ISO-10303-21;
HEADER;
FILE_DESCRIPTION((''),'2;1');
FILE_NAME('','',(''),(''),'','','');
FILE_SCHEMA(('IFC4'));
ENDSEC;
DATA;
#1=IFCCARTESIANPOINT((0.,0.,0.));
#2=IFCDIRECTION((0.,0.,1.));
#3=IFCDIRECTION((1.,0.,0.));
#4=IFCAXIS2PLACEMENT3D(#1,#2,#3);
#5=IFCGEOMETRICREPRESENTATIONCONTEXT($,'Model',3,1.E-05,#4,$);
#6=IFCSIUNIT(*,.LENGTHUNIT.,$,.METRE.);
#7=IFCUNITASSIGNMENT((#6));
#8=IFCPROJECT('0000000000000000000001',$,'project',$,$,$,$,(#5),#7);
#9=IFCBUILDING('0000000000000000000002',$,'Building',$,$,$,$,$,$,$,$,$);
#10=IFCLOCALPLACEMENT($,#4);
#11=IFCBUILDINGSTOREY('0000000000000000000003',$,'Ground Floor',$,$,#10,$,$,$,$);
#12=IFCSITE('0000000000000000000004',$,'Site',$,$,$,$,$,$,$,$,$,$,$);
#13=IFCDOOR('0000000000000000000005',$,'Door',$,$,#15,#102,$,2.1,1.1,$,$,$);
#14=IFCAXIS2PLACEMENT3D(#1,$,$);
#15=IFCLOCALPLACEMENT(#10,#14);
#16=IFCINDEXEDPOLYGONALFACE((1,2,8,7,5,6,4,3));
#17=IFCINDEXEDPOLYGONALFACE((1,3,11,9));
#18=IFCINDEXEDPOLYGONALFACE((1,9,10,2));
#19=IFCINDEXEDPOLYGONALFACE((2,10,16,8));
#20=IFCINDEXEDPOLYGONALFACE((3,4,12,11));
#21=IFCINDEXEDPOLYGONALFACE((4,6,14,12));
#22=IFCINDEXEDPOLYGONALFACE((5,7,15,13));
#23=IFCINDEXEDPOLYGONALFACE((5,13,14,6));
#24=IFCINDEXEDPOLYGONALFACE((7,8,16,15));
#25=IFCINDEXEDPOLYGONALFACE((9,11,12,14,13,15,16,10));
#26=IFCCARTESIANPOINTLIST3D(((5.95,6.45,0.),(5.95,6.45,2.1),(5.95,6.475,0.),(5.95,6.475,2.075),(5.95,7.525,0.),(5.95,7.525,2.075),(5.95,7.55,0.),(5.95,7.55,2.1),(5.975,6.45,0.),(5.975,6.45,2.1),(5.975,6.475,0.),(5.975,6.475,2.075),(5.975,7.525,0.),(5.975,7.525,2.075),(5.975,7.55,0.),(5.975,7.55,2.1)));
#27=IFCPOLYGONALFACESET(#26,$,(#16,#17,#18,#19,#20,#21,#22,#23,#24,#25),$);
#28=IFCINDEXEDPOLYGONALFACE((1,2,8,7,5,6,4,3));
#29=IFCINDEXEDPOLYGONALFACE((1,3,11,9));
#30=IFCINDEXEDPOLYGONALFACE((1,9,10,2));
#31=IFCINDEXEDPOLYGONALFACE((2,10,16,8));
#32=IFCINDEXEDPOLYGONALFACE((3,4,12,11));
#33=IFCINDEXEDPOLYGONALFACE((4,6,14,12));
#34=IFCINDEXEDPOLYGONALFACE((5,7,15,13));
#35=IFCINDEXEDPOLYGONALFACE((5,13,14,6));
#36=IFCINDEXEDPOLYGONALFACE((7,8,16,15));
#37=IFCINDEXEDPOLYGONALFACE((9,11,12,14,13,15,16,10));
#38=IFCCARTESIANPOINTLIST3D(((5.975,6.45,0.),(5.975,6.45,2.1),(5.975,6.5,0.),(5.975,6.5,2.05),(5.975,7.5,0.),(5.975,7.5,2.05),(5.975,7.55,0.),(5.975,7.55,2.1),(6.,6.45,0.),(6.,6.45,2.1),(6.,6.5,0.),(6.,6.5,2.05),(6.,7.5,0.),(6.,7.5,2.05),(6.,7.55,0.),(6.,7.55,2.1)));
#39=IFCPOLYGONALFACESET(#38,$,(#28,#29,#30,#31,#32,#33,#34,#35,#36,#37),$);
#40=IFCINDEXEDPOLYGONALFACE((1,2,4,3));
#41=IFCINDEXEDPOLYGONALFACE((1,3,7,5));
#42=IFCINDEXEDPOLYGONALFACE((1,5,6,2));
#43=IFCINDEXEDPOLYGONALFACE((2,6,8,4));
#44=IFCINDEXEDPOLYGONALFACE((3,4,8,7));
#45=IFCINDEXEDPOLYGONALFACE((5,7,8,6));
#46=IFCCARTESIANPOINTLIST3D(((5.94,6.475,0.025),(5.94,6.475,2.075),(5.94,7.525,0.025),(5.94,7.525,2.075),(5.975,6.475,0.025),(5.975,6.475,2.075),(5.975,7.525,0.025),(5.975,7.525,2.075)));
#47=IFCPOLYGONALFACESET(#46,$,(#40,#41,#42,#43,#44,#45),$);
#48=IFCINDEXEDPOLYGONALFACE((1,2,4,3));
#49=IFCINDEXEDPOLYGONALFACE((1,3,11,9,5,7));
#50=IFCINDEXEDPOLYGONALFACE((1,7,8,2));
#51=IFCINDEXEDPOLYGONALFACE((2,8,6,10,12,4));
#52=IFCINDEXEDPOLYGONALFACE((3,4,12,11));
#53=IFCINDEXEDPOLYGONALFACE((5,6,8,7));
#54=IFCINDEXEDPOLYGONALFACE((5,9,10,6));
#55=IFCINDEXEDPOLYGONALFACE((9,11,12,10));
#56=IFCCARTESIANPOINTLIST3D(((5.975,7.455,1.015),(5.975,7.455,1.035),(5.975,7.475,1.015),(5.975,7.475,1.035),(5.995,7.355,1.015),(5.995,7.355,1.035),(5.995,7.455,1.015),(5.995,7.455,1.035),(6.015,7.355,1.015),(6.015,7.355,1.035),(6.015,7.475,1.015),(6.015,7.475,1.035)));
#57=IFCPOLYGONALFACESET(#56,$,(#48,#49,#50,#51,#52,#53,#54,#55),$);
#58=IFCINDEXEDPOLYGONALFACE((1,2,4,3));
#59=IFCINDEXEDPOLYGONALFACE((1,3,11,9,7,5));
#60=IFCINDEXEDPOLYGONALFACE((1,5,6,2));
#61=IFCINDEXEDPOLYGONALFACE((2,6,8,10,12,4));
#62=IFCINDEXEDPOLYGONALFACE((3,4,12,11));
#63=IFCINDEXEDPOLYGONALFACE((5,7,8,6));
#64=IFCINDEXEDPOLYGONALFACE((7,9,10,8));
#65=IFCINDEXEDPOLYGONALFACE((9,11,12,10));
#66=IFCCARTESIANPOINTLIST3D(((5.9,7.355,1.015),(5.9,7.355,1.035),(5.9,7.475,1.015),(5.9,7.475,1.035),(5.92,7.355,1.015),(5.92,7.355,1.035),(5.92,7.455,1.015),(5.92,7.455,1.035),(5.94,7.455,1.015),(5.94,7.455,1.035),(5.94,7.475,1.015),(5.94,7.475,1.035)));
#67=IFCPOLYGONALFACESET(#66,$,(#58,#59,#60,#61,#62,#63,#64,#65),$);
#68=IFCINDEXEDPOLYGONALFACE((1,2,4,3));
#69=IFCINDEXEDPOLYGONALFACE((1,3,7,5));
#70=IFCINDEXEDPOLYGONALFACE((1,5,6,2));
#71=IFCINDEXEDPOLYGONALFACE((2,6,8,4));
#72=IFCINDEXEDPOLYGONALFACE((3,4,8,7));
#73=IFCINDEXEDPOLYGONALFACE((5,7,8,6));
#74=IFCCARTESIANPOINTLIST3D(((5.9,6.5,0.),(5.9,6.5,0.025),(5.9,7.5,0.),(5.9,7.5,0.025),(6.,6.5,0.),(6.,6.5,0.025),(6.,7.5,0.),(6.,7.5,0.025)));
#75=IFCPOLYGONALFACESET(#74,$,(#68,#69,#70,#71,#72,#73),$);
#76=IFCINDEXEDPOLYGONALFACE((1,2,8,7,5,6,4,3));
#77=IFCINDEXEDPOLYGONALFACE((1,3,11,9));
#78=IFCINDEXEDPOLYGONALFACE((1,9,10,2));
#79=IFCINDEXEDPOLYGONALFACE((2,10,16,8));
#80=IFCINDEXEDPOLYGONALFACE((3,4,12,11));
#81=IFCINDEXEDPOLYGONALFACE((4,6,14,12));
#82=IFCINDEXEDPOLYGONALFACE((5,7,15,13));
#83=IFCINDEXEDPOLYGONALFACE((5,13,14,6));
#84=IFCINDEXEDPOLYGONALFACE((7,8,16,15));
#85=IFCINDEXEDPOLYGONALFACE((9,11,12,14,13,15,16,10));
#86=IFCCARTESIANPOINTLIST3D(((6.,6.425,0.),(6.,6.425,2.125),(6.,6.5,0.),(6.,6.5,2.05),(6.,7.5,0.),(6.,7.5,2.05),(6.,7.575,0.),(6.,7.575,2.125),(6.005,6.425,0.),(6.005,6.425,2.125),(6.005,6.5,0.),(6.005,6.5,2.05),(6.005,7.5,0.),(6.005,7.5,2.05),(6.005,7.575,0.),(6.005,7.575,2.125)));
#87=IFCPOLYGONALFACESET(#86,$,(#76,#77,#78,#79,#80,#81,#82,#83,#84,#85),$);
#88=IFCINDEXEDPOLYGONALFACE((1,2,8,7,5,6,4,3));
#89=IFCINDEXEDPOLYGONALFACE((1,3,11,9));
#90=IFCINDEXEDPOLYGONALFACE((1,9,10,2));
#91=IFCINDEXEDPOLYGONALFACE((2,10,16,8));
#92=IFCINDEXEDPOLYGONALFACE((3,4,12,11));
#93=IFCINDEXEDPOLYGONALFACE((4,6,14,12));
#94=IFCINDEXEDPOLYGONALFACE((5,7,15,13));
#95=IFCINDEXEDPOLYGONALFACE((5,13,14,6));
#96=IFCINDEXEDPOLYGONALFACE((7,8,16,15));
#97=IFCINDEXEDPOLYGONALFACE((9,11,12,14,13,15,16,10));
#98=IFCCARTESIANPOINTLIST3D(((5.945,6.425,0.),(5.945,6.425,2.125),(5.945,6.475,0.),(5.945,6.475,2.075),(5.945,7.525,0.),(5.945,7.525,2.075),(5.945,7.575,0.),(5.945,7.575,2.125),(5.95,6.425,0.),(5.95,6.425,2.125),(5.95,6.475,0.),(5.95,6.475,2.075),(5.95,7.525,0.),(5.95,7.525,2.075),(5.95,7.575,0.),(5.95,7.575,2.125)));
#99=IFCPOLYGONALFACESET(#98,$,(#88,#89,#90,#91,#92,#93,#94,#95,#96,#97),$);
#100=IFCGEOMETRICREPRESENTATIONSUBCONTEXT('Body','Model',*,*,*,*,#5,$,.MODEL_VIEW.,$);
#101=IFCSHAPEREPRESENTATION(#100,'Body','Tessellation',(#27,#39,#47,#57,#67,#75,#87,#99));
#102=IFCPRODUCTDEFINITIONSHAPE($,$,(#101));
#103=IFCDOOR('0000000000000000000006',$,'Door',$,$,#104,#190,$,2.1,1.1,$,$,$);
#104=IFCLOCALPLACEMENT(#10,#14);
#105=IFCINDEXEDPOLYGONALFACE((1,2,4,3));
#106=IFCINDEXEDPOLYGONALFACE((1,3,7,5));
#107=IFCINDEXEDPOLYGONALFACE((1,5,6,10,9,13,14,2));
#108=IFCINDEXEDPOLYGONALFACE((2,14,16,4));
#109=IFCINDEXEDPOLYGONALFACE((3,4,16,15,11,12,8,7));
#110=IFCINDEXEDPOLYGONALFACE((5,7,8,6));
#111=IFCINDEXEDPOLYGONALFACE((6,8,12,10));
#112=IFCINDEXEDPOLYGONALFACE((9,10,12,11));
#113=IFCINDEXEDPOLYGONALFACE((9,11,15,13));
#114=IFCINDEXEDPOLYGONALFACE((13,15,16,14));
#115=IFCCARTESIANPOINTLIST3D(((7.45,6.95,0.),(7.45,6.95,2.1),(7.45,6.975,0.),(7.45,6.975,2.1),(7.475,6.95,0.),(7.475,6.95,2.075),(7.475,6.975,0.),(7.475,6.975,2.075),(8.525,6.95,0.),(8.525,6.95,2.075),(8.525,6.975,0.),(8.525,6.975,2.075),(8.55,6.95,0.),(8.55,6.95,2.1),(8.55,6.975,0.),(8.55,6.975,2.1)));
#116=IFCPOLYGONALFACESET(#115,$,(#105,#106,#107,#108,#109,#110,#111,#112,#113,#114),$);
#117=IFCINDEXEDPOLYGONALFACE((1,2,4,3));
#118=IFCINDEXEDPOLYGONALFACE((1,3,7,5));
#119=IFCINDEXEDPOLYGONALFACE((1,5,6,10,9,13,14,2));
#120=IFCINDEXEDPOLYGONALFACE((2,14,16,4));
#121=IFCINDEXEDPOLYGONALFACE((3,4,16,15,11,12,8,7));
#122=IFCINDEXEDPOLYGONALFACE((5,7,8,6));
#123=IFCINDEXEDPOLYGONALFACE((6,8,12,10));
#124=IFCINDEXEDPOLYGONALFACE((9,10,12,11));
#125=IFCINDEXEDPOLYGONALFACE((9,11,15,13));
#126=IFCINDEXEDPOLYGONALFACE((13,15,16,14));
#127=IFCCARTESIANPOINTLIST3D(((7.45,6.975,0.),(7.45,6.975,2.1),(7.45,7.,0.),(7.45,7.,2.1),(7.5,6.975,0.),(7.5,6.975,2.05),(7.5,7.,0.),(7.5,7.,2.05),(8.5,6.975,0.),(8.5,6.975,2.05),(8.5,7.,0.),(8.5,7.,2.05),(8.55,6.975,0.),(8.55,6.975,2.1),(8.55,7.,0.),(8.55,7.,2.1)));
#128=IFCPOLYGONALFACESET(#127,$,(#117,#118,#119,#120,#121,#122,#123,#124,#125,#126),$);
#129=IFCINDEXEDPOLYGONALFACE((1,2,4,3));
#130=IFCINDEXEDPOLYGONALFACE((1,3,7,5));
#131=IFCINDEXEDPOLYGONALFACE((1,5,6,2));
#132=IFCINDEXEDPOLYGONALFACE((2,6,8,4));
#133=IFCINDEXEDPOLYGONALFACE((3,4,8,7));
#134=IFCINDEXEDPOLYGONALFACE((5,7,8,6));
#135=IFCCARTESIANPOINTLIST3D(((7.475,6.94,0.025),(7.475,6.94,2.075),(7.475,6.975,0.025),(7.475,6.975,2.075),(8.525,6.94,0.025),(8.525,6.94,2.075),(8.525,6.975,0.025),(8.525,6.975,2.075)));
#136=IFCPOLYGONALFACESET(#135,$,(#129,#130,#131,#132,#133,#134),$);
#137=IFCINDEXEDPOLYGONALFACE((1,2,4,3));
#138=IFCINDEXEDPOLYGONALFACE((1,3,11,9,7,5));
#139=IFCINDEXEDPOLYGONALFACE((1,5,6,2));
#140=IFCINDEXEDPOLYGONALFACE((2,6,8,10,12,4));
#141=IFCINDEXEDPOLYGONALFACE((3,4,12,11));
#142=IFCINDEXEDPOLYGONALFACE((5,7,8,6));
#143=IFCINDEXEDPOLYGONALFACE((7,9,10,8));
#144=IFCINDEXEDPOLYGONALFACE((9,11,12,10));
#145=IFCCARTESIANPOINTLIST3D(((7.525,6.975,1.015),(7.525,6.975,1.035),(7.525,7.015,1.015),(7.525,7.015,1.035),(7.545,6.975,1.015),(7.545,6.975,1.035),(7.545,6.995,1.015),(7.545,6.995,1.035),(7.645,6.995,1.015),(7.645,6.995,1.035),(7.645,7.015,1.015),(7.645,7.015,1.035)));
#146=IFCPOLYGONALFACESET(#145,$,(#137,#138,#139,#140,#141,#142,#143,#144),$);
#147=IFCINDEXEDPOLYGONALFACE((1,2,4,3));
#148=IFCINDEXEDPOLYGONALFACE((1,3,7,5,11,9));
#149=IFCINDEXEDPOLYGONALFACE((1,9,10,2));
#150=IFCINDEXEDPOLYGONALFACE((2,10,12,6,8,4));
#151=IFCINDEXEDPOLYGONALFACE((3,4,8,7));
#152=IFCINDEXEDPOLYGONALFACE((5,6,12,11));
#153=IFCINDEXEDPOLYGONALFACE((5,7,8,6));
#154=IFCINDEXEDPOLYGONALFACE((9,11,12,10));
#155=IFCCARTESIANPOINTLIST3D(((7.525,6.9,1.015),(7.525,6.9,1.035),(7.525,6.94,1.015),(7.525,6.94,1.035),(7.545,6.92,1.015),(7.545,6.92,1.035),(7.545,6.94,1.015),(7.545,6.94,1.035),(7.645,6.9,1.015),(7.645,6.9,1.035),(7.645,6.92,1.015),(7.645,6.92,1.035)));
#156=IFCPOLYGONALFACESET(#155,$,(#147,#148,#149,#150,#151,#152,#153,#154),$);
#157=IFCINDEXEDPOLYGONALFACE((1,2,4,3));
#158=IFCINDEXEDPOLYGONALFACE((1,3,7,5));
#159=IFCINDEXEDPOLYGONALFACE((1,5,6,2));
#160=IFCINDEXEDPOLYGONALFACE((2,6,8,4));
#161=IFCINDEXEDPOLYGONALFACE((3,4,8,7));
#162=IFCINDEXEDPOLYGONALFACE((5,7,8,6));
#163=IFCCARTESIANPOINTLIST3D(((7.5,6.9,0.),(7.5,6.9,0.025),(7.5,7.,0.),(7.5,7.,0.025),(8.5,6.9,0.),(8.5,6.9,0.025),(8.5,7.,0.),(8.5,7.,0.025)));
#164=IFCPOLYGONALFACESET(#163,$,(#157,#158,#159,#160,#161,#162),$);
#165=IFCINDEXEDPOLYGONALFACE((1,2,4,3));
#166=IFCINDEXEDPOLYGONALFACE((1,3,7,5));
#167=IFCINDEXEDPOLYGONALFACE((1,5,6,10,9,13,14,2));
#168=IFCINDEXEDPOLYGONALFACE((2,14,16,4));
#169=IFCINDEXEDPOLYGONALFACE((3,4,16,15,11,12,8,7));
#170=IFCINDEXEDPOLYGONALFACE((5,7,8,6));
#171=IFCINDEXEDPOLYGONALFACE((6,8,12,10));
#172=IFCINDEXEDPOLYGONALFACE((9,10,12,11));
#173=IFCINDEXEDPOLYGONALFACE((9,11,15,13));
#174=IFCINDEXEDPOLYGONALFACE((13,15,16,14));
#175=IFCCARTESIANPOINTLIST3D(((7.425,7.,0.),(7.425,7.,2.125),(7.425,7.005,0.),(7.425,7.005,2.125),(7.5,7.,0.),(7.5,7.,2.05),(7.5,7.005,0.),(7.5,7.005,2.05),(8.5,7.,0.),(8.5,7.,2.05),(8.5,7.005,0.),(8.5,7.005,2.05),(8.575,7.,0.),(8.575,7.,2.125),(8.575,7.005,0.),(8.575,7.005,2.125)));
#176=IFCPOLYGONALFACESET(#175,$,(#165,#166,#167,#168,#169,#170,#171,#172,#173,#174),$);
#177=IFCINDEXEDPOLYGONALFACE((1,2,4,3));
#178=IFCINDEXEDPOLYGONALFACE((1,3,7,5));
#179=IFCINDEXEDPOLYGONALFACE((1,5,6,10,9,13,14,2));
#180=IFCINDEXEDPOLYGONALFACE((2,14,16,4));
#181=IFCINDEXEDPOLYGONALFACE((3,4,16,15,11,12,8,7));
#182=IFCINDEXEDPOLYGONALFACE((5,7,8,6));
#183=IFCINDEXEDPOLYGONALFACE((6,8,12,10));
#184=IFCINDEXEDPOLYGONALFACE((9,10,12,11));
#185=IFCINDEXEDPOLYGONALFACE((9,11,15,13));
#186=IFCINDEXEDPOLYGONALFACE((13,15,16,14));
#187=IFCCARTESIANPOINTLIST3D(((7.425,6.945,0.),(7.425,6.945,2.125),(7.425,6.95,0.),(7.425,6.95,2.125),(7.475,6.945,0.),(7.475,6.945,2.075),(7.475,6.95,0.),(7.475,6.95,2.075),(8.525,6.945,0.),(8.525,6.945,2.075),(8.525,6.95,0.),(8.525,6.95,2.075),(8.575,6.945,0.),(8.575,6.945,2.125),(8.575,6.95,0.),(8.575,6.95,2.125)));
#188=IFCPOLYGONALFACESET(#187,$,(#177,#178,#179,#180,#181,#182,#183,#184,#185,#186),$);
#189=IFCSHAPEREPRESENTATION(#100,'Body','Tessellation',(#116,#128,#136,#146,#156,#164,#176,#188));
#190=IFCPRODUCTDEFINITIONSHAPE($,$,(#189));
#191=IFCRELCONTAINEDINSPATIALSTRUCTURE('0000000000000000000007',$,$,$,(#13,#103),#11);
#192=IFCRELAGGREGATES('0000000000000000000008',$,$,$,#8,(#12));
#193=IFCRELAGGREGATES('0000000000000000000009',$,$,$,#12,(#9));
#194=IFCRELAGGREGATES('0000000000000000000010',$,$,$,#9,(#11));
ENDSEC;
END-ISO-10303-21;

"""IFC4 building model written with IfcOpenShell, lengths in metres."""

from ifc_helpers import new_model, si_unit, frame, origin_with_axes, place, context, subcontext, project, spatial, line, indexed_curve, outline, extrude, element, save


model = new_model("IFC4")

# Units and contexts
model_context = context("Model", 3, precision=1e-05, world=origin_with_axes())
body_context = subcontext(model_context, "Body", "Model", "MODEL_VIEW")
ifc_project = project(units=[si_unit("LENGTHUNIT", "METRE")], contexts=[model_context])

# Site, building, storey
site = spatial("IfcSite", under=ifc_project, Name="Site")
building = spatial("IfcBuilding", under=site, Name="Building")
storey_placement = place(None, origin_with_axes())
storey = spatial("IfcBuildingStorey", under=building, at=storey_placement, Name="Ground Floor")

# Doors
door_1_placement = place(storey_placement, frame((6.0, 6.45, 0.0), z_axis=(0.0, 0.0, 1.0), x_axis=(0.0, 1.0, 0.0)))
element("IfcDoor", 1, at=door_1_placement, inside=storey, Name="Door", OverallHeight=2.1, OverallWidth=1.1, context=body_context, shape_type="SweptSolid", body=[
    extrude(outline(indexed_curve([(0.0, 0.0), (0.0, 2.1), (1.1, 2.1), (1.1, 0.0), (1.075, 0.0), (1.075, 2.075), (0.025, 2.075), (0.025, 0.0)], segments=[line(1, 2, 3, 4, 5, 6, 7, 8, 1)])), frame((0.0, 0.025, 0.0), z_axis=(0.0, -1.0, 0.0), x_axis=(1.0, 0.0, 0.0)), (0.0, 0.0, -1.0), 0.025),
    extrude(outline(indexed_curve([(0.0, 0.0), (0.0, 2.1), (1.1, 2.1), (1.1, 0.0), (1.05, 0.0), (1.05, 2.05), (0.05, 2.05), (0.05, 0.0)], segments=[line(1, 2, 3, 4, 5, 6, 7, 8, 1)])), frame((0.0, 0.0, 0.0), z_axis=(0.0, -1.0, 0.0), x_axis=(1.0, 0.0, 0.0)), (0.0, 0.0, -1.0), 0.025),
    extrude(outline(indexed_curve([(0.0, 0.0), (1.05, 0.0), (1.05, 0.035), (0.0, 0.035)], segments=[line(1, 2, 3, 4, 1)])), frame((0.025, 0.025, 0.025), z_axis=(0.0, 0.0, 1.0), x_axis=(1.0, 0.0, 0.0)), (0.0, 0.0, 1.0), 2.05),
    extrude(outline(indexed_curve([(0.0, 0.0), (0.0, -0.04), (-0.12, -0.04), (-0.12, -0.02), (-0.02, -0.02), (-0.02, 0.0)], segments=[line(1, 2, 3, 4, 5, 6, 1)])), frame((1.025, 0.025, 1.015), z_axis=(0.0, 0.0, 1.0), x_axis=(1.0, 0.0, 0.0)), (0.0, 0.0, 1.0), 0.02),
    extrude(outline(indexed_curve([(0.0, 0.0), (0.0, 0.04), (-0.12, 0.04), (-0.12, 0.02), (-0.02, 0.02), (-0.02, 0.0)], segments=[line(1, 2, 3, 4, 5, 6, 1)])), frame((1.025, 0.06, 1.015), z_axis=(0.0, 0.0, 1.0), x_axis=(1.0, 0.0, 0.0)), (0.0, 0.0, 1.0), 0.02),
    extrude(outline(indexed_curve([(0.0, 0.0), (1.0, 0.0), (1.0, 0.1), (0.0, 0.1)], segments=[line(1, 2, 3, 4, 1)])), frame((0.05, 0.0, 0.0), z_axis=(0.0, 0.0, 1.0), x_axis=(1.0, 0.0, 0.0)), (0.0, 0.0, 1.0), 0.025),
    extrude(outline(indexed_curve([(0.0, 0.0), (0.0, 2.125), (1.15, 2.125), (1.15, 0.0), (1.075, 0.0), (1.075, 2.05), (0.075, 2.05), (0.075, 0.0)], segments=[line(1, 2, 3, 4, 5, 6, 7, 8, 1)])), frame((-0.025, -0.005, 0.0), z_axis=(0.0, -1.0, 0.0), x_axis=(1.0, 0.0, 0.0)), (0.0, 0.0, -1.0), 0.005),
    extrude(outline(indexed_curve([(0.0, 0.0), (0.0, 2.125), (1.15, 2.125), (1.15, 0.0), (1.1, 0.0), (1.1, 2.075), (0.05, 2.075), (0.05, 0.0)], segments=[line(1, 2, 3, 4, 5, 6, 7, 8, 1)])), frame((-0.025, 0.05, 0.0), z_axis=(0.0, -1.0, 0.0), x_axis=(1.0, 0.0, 0.0)), (0.0, 0.0, -1.0), 0.005),
])
door_2_placement = place(storey_placement, frame((8.55, 7.0, 0.0), z_axis=(0.0, 0.0, 1.0), x_axis=(-1.0, 0.0, 0.0)))
element("IfcDoor", 2, at=door_2_placement, inside=storey, Name="Door", OverallHeight=2.1, OverallWidth=1.1, context=body_context, shape_type="SweptSolid", body=[
    extrude(outline(indexed_curve([(0.0, 0.0), (0.0, 2.1), (1.1, 2.1), (1.1, 0.0), (1.075, 0.0), (1.075, 2.075), (0.025, 2.075), (0.025, 0.0)], segments=[line(1, 2, 3, 4, 5, 6, 7, 8, 1)])), frame((0.0, 0.025, 0.0), z_axis=(0.0, -1.0, 0.0), x_axis=(1.0, 0.0, 0.0)), (0.0, 0.0, -1.0), 0.025),
    extrude(outline(indexed_curve([(0.0, 0.0), (0.0, 2.1), (1.1, 2.1), (1.1, 0.0), (1.05, 0.0), (1.05, 2.05), (0.05, 2.05), (0.05, 0.0)], segments=[line(1, 2, 3, 4, 5, 6, 7, 8, 1)])), frame((0.0, 0.0, 0.0), z_axis=(0.0, -1.0, 0.0), x_axis=(1.0, 0.0, 0.0)), (0.0, 0.0, -1.0), 0.025),
    extrude(outline(indexed_curve([(0.0, 0.0), (1.05, 0.0), (1.05, 0.035), (0.0, 0.035)], segments=[line(1, 2, 3, 4, 1)])), frame((0.025, 0.025, 0.025), z_axis=(0.0, 0.0, 1.0), x_axis=(1.0, 0.0, 0.0)), (0.0, 0.0, 1.0), 2.05),
    extrude(outline(indexed_curve([(0.0, 0.0), (0.0, -0.04), (-0.12, -0.04), (-0.12, -0.02), (-0.02, -0.02), (-0.02, 0.0)], segments=[line(1, 2, 3, 4, 5, 6, 1)])), frame((1.025, 0.025, 1.015), z_axis=(0.0, 0.0, 1.0), x_axis=(1.0, 0.0, 0.0)), (0.0, 0.0, 1.0), 0.02),
    extrude(outline(indexed_curve([(0.0, 0.0), (0.0, 0.04), (-0.12, 0.04), (-0.12, 0.02), (-0.02, 0.02), (-0.02, 0.0)], segments=[line(1, 2, 3, 4, 5, 6, 1)])), frame((1.025, 0.06, 1.015), z_axis=(0.0, 0.0, 1.0), x_axis=(1.0, 0.0, 0.0)), (0.0, 0.0, 1.0), 0.02),
    extrude(outline(indexed_curve([(0.0, 0.0), (1.0, 0.0), (1.0, 0.1), (0.0, 0.1)], segments=[line(1, 2, 3, 4, 1)])), frame((0.05, 0.0, 0.0), z_axis=(0.0, 0.0, 1.0), x_axis=(1.0, 0.0, 0.0)), (0.0, 0.0, 1.0), 0.025),
    extrude(outline(indexed_curve([(0.0, 0.0), (0.0, 2.125), (1.15, 2.125), (1.15, 0.0), (1.075, 0.0), (1.075, 2.05), (0.075, 2.05), (0.075, 0.0)], segments=[line(1, 2, 3, 4, 5, 6, 7, 8, 1)])), frame((-0.025, -0.005, 0.0), z_axis=(0.0, -1.0, 0.0), x_axis=(1.0, 0.0, 0.0)), (0.0, 0.0, -1.0), 0.005),
    extrude(outline(indexed_curve([(0.0, 0.0), (0.0, 2.125), (1.15, 2.125), (1.15, 0.0), (1.1, 0.0), (1.1, 2.075), (0.05, 2.075), (0.05, 0.0)], segments=[line(1, 2, 3, 4, 5, 6, 7, 8, 1)])), frame((-0.025, 0.05, 0.0), z_axis=(0.0, -1.0, 0.0), x_axis=(1.0, 0.0, 0.0)), (0.0, 0.0, -1.0), 0.005),
])

save(model, "model.ifc")
